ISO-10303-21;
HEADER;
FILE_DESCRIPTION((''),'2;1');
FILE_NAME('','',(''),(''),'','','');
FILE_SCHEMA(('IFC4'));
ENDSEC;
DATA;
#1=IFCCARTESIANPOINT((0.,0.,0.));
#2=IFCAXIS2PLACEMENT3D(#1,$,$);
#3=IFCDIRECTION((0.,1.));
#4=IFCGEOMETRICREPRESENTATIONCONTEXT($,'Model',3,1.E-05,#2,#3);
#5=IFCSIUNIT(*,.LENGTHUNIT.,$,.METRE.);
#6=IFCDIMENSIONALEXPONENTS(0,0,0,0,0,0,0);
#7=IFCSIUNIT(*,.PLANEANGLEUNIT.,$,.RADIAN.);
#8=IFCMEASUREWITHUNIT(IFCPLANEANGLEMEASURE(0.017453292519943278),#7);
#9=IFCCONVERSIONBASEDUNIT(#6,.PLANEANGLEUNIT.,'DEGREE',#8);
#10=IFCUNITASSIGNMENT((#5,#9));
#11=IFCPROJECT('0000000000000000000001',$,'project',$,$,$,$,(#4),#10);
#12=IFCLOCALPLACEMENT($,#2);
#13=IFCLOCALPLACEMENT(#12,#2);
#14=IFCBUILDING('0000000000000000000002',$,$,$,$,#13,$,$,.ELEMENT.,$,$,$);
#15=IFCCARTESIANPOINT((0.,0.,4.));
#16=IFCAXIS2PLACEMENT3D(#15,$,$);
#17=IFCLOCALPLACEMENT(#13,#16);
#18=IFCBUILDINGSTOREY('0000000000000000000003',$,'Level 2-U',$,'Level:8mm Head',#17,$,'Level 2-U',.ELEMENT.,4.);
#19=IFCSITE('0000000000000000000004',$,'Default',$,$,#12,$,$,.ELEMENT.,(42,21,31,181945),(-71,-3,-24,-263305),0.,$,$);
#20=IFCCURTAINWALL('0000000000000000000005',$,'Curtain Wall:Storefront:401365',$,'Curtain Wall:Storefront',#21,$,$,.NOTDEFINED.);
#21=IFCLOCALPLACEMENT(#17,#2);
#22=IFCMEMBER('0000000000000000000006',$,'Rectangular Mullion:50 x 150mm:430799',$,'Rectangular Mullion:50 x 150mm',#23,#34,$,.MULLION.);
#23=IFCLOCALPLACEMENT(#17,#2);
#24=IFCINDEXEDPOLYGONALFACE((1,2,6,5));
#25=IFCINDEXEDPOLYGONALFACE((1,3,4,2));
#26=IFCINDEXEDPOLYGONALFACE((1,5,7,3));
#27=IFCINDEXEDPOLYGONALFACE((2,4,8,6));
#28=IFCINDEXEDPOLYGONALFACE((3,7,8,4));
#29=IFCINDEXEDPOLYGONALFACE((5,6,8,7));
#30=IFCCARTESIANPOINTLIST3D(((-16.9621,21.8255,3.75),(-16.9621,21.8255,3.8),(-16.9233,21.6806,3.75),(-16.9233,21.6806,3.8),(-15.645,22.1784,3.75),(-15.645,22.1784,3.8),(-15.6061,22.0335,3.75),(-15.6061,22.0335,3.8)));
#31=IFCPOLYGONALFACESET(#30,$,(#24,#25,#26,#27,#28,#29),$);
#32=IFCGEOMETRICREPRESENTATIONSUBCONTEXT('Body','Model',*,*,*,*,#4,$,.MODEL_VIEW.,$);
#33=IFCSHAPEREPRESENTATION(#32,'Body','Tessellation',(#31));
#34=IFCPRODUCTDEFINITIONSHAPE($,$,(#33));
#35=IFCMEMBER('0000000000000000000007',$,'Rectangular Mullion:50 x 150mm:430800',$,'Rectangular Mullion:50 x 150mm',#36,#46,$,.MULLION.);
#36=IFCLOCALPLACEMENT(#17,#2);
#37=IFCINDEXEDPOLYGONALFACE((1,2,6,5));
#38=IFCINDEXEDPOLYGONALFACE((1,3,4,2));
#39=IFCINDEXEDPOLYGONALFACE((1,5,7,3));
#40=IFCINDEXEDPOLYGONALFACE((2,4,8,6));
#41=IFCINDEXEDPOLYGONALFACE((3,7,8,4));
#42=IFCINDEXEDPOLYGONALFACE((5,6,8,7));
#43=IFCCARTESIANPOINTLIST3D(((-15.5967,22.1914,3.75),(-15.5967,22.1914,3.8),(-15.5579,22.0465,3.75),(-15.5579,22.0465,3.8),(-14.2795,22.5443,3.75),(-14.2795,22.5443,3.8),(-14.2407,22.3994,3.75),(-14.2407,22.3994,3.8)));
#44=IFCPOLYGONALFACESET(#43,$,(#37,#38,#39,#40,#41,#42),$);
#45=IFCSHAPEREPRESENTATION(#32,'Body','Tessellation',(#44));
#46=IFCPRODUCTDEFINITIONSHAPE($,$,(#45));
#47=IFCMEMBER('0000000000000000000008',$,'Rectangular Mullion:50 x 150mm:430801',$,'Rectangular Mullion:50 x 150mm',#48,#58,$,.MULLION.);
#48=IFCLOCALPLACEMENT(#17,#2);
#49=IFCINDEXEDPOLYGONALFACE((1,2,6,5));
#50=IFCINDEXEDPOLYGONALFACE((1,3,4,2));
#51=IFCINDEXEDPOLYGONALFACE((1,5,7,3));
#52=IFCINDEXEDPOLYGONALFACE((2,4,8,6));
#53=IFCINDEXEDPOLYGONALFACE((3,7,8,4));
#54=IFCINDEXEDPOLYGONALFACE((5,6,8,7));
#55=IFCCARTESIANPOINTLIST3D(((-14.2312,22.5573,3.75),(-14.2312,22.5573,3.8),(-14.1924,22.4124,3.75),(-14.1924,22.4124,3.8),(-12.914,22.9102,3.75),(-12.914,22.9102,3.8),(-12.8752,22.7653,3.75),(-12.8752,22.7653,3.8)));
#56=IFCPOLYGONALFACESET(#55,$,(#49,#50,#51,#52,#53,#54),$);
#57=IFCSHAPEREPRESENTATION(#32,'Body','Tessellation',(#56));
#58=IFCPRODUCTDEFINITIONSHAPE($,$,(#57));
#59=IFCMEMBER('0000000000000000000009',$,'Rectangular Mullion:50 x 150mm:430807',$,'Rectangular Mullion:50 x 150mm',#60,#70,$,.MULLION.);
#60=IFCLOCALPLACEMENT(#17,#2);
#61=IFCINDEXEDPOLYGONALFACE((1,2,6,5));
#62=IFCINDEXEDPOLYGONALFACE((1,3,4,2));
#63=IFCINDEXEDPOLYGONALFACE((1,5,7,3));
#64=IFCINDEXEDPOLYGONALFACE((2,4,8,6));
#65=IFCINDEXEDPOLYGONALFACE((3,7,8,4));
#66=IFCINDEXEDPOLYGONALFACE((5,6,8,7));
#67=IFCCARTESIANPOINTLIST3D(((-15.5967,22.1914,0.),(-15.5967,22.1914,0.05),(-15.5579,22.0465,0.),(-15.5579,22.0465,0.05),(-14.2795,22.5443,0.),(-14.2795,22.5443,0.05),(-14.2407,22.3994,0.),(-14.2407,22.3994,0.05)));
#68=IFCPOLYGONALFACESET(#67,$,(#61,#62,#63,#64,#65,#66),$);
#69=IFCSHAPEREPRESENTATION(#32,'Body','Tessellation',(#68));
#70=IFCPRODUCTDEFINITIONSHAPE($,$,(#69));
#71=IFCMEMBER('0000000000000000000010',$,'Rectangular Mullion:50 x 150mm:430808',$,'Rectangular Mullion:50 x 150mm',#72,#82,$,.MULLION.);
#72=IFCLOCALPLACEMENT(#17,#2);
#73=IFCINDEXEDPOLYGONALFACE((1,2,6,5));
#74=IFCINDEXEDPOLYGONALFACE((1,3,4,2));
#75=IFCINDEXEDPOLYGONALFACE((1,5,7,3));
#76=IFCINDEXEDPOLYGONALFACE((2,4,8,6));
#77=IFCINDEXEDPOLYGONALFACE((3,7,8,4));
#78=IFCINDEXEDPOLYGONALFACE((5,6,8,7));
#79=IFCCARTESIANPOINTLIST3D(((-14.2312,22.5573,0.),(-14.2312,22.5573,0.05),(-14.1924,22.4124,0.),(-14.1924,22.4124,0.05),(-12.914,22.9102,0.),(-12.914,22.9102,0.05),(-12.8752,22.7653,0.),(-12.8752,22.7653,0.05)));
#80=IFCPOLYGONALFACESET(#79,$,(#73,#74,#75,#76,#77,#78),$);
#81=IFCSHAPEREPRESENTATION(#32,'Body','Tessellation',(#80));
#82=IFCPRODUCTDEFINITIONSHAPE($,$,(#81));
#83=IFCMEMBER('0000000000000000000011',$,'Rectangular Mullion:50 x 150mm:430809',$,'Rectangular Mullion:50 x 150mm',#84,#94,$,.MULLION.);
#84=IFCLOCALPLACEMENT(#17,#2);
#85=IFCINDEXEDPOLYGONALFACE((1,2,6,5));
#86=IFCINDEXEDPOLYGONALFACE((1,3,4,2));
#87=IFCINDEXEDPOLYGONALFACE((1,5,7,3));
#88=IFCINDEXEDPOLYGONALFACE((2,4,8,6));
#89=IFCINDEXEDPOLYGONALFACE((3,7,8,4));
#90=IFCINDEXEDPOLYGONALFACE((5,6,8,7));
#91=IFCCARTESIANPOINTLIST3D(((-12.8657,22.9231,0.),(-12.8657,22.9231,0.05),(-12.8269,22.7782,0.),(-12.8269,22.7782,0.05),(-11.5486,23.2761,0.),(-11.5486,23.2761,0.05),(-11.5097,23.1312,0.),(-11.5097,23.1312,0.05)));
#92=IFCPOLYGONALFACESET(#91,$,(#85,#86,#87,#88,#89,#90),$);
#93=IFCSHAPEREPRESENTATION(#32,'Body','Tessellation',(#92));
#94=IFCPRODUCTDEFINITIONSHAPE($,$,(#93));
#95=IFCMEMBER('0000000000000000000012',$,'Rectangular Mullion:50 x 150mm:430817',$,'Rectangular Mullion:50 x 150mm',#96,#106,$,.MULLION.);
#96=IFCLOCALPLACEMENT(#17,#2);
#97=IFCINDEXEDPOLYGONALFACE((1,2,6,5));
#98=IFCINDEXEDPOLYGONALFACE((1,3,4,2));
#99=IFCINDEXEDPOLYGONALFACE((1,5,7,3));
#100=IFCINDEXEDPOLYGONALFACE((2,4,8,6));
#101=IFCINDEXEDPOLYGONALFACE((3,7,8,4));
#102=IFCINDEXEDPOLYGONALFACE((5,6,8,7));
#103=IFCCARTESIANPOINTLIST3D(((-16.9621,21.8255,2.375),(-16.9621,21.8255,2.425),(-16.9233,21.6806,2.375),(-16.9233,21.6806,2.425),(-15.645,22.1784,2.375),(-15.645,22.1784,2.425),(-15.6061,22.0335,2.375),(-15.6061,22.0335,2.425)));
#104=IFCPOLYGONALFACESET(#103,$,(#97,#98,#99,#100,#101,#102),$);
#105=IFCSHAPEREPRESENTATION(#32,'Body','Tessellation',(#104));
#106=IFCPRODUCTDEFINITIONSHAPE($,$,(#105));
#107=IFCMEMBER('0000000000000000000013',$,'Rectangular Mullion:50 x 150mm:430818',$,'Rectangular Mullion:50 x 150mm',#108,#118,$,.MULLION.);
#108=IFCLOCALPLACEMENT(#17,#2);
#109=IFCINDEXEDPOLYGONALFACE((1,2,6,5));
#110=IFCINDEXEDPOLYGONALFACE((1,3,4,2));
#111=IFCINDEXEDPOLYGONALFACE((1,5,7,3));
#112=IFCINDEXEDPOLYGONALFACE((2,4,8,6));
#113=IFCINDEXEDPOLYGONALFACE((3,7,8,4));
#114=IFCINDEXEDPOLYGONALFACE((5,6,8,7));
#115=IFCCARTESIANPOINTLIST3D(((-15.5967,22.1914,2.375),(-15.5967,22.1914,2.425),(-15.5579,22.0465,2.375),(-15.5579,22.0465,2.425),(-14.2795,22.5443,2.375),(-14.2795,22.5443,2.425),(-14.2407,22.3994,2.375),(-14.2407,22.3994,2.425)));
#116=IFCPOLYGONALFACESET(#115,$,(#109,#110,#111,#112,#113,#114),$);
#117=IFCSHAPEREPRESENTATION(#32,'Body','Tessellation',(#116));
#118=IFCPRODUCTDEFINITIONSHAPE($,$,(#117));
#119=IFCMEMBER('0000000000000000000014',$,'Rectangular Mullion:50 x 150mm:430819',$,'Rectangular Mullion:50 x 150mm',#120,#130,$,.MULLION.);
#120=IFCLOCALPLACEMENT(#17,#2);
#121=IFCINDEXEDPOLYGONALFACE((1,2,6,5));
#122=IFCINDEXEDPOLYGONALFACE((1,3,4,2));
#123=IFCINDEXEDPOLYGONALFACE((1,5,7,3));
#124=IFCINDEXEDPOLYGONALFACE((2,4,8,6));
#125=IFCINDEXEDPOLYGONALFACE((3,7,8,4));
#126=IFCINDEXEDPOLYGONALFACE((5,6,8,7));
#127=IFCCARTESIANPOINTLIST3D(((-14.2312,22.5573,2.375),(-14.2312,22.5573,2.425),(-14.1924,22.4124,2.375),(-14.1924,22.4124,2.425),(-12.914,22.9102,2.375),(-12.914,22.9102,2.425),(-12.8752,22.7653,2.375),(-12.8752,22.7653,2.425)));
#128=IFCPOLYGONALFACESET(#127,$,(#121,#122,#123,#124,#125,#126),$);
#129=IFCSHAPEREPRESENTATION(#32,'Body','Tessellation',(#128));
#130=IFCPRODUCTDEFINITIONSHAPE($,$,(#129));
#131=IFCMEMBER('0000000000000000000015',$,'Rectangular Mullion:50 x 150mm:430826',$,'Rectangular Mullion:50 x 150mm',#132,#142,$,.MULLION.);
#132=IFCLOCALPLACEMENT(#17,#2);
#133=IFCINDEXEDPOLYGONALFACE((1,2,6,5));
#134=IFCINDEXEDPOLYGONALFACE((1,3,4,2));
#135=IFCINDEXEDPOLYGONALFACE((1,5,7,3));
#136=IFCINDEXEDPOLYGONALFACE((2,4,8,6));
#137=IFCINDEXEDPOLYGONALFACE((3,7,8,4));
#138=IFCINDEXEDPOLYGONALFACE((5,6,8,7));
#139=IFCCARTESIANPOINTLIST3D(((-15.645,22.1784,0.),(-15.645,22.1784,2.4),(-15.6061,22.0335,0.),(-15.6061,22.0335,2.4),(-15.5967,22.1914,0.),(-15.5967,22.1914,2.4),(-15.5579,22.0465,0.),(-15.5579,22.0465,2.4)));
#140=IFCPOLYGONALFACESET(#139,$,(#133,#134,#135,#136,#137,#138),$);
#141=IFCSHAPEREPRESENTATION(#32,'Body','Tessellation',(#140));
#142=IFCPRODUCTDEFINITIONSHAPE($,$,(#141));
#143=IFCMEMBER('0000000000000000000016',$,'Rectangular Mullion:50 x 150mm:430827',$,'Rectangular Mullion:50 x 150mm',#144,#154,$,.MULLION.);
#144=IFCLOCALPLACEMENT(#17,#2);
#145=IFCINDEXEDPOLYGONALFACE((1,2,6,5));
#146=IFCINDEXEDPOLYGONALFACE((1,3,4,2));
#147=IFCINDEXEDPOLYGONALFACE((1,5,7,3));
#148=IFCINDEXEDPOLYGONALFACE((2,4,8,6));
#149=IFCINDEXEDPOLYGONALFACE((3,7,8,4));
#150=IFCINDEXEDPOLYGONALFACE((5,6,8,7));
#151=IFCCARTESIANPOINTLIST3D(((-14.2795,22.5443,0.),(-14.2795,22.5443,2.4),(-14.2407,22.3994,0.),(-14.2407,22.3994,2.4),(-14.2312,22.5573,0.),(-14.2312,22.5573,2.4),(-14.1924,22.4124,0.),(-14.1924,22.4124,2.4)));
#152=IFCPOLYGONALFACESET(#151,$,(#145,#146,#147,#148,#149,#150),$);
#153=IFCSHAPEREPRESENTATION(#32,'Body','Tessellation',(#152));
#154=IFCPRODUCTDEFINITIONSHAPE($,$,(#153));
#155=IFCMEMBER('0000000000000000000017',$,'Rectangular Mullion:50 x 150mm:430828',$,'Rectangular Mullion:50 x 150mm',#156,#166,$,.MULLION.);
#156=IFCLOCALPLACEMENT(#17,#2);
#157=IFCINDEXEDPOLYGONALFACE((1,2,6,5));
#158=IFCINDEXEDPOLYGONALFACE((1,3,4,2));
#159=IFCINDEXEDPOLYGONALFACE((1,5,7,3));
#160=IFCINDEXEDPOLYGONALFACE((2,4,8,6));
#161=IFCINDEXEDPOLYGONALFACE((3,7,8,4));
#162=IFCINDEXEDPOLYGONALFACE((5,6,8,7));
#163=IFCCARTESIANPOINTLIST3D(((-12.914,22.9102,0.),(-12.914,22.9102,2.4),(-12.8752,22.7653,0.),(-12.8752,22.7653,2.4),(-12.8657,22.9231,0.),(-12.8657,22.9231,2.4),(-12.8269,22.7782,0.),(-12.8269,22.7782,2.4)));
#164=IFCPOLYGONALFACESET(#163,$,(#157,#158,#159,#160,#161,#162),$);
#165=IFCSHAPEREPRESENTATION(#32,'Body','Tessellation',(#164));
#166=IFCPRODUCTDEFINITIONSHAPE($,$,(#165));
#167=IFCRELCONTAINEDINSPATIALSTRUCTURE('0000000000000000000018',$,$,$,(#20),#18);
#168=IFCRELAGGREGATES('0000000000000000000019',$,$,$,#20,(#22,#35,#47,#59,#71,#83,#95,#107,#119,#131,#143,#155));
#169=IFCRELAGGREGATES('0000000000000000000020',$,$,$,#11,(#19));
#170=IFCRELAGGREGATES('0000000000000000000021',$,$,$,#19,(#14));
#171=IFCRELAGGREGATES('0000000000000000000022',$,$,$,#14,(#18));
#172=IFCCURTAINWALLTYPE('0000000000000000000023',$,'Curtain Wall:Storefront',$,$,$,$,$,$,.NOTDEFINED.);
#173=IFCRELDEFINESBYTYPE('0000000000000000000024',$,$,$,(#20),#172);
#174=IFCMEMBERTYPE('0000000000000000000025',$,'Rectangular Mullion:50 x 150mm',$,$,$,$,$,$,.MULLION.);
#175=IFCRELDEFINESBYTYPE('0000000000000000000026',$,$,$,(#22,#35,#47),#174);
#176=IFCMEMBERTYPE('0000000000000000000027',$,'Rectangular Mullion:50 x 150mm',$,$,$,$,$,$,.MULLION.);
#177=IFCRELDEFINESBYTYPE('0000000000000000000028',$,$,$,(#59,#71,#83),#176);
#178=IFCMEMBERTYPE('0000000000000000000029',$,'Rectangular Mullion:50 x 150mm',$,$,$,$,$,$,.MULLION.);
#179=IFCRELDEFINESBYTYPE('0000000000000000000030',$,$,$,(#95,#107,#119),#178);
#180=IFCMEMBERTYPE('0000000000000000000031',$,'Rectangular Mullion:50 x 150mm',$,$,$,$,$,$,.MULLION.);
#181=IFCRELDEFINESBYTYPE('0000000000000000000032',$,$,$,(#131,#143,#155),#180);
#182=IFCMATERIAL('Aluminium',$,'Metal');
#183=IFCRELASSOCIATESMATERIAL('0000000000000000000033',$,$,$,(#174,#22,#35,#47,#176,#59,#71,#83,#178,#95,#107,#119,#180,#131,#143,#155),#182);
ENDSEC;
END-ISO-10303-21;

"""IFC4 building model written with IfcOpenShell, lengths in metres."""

from ifc_helpers import new_model, entity, si_unit, converted_unit, direction, frame, origin, place, context, subcontext, project, spatial, indexed_curve, outline, extrude, source, transform, mapped, material, type_object, type_shapes, element, aggregate, save


model = new_model("IFC4")

# Units and contexts
model_context = context("Model", 3, precision=1e-05, world=origin(), true_north=direction((0.0, 1.0)))
body_context = subcontext(model_context, "Body", "Model", "MODEL_VIEW")
ifc_project = project(units=[si_unit("LENGTHUNIT", "METRE"), converted_unit("PLANEANGLEUNIT", "DEGREE", entity("IfcPlaneAngleMeasure", 0.017453292519943278), si_unit("PLANEANGLEUNIT", "RADIAN"), dimensions=[0, 0, 0, 0, 0, 0, 0])], contexts=[model_context])

# Site, building, storey
site_placement = place(None, origin())
site = spatial("IfcSite", under=ifc_project, at=site_placement, Name="Default", CompositionType="ELEMENT", RefLatitude=(42, 21, 31, 181945), RefLongitude=(-71, -3, -24, -263305), RefElevation=0.0)
building_placement = place(site_placement, origin())
building = spatial("IfcBuilding", under=site, at=building_placement, CompositionType="ELEMENT")
storey_placement = place(building_placement, frame((0.0, 0.0, 4.0)))
storey = spatial("IfcBuildingStorey", under=building, at=storey_placement, Name="Level 2-U", ObjectType="Level:8mm Head", LongName="Level 2-U", CompositionType="ELEMENT", Elevation=4.0)

# Curtain wall, members
curtain_wall_type = type_object("IfcCurtainWallType", Name="Curtain Wall:Storefront", PredefinedType="NOTDEFINED")
curtain_wall_placement = place(storey_placement, frame((0.0, 0.0, -4.0)))
curtain_wall = element("IfcCurtainWall", 1, at=curtain_wall_placement, inside=storey, type_object=curtain_wall_type, Name="Curtain Wall:Storefront:401365", ObjectType="Curtain Wall:Storefront", PredefinedType="NOTDEFINED")
ifc_material_1 = material(Name="Aluminium", Category="Metal")
member_type_1 = type_object("IfcMemberType", Name="Rectangular Mullion:50 x 150mm", PredefinedType="MULLION", material=ifc_material_1)
shared_shape_1 = source(origin(), body_context, "Body", "SweptSolid", [
    extrude(outline(indexed_curve([(-0.025, -0.075), (0.025, -0.075), (0.025, 0.075), (-0.025, 0.075), (-0.025, -0.075)], self_intersect=False)), frame((-0.025, 0.0, -1.3636), z_axis=(0.0, 0.0, 1.0), x_axis=(-1.0, 0.0, 0.0)), (0.0, 0.0, 1.0), 1.3636),
])
type_shapes(member_type_1, [shared_shape_1])
member_1_placement = place(curtain_wall_placement, frame((-15.6256, 22.106, 7.8), z_axis=(0.965926, 0.258819, 0.0), x_axis=(0.0, 0.0, 1.0)))
member_1 = element("IfcMember", 2, at=member_1_placement, type_object=member_type_1, material=ifc_material_1, Name="Rectangular Mullion:50 x 150mm:430799", ObjectType="Rectangular Mullion:50 x 150mm", PredefinedType="MULLION", context=body_context, shape_type="MappedRepresentation", body=[
    mapped(shared_shape_1, transform((0.0, 0.0, 0.0), scale=1.0)),
])
member_2_placement = place(curtain_wall_placement, frame((-14.2601, 22.4719, 7.8), z_axis=(0.965926, 0.258819, 0.0), x_axis=(0.0, 0.0, 1.0)))
member_2 = element("IfcMember", 3, at=member_2_placement, type_object=member_type_1, material=ifc_material_1, Name="Rectangular Mullion:50 x 150mm:430800", ObjectType="Rectangular Mullion:50 x 150mm", PredefinedType="MULLION", context=body_context, shape_type="MappedRepresentation", body=[
    mapped(shared_shape_1, transform((0.0, 0.0, 0.0), scale=1.0)),
])
member_3_placement = place(curtain_wall_placement, frame((-12.8946, 22.8377, 7.8), z_axis=(0.965926, 0.258819, 0.0), x_axis=(0.0, 0.0, 1.0)))
member_3 = element("IfcMember", 4, at=member_3_placement, type_object=member_type_1, material=ifc_material_1, Name="Rectangular Mullion:50 x 150mm:430801", ObjectType="Rectangular Mullion:50 x 150mm", PredefinedType="MULLION", context=body_context, shape_type="MappedRepresentation", body=[
    mapped(shared_shape_1, transform((0.0, 0.0, 0.0), scale=1.0)),
])
member_type_2 = type_object("IfcMemberType", Name="Rectangular Mullion:50 x 150mm", PredefinedType="MULLION", material=ifc_material_1)
shared_shape_2 = source(origin(), body_context, "Body", "SweptSolid", [
    extrude(outline(indexed_curve([(-0.025, -0.075), (0.025, -0.075), (0.025, 0.075), (-0.025, 0.075), (-0.025, -0.075)], self_intersect=False)), frame((-0.025, 0.0, -1.3636), z_axis=(0.0, 0.0, 1.0), x_axis=(-1.0, 0.0, 0.0)), (0.0, 0.0, 1.0), 1.3636),
])
type_shapes(member_type_2, [shared_shape_2])
member_4_placement = place(curtain_wall_placement, frame((-15.5773, 22.1189, 4.0), z_axis=(-0.965926, -0.258819, 0.0), x_axis=(0.0, 0.0, -1.0)))
member_4 = element("IfcMember", 5, at=member_4_placement, type_object=member_type_2, material=ifc_material_1, Name="Rectangular Mullion:50 x 150mm:430807", ObjectType="Rectangular Mullion:50 x 150mm", PredefinedType="MULLION", context=body_context, shape_type="MappedRepresentation", body=[
    mapped(shared_shape_2, transform((0.0, 0.0, 0.0), scale=1.0)),
])
member_5_placement = place(curtain_wall_placement, frame((-14.2118, 22.4848, 4.0), z_axis=(-0.965926, -0.258819, 0.0), x_axis=(0.0, 0.0, -1.0)))
member_5 = element("IfcMember", 6, at=member_5_placement, type_object=member_type_2, material=ifc_material_1, Name="Rectangular Mullion:50 x 150mm:430808", ObjectType="Rectangular Mullion:50 x 150mm", PredefinedType="MULLION", context=body_context, shape_type="MappedRepresentation", body=[
    mapped(shared_shape_2, transform((0.0, 0.0, 0.0), scale=1.0)),
])
member_6_placement = place(curtain_wall_placement, frame((-12.8463, 22.8507, 4.0), z_axis=(-0.965926, -0.258819, 0.0), x_axis=(0.0, 0.0, -1.0)))
member_6 = element("IfcMember", 7, at=member_6_placement, type_object=member_type_2, material=ifc_material_1, Name="Rectangular Mullion:50 x 150mm:430809", ObjectType="Rectangular Mullion:50 x 150mm", PredefinedType="MULLION", context=body_context, shape_type="MappedRepresentation", body=[
    mapped(shared_shape_2, transform((0.0, 0.0, 0.0), scale=1.0)),
])
member_type_3 = type_object("IfcMemberType", Name="Rectangular Mullion:50 x 150mm", PredefinedType="MULLION", material=ifc_material_1)
shared_shape_3 = source(origin(), body_context, "Body", "SweptSolid", [
    extrude(outline(indexed_curve([(-0.025, -0.075), (0.025, -0.075), (0.025, 0.075), (-0.025, 0.075), (-0.025, -0.075)], self_intersect=False)), frame((0.0, 0.0, -1.3636), z_axis=(0.0, 0.0, 1.0), x_axis=(-1.0, 0.0, 0.0)), (0.0, 0.0, 1.0), 1.3636),
])
type_shapes(member_type_3, [shared_shape_3])
member_7_placement = place(curtain_wall_placement, frame((-15.6256, 22.106, 6.4), z_axis=(0.965926, 0.258819, 0.0), x_axis=(0.0, 0.0, 1.0)))
member_7 = element("IfcMember", 8, at=member_7_placement, type_object=member_type_3, material=ifc_material_1, Name="Rectangular Mullion:50 x 150mm:430817", ObjectType="Rectangular Mullion:50 x 150mm", PredefinedType="MULLION", context=body_context, shape_type="MappedRepresentation", body=[
    mapped(shared_shape_3, transform((0.0, 0.0, 0.0), scale=1.0)),
])
member_8_placement = place(curtain_wall_placement, frame((-14.2601, 22.4719, 6.4), z_axis=(0.965926, 0.258819, 0.0), x_axis=(0.0, 0.0, 1.0)))
member_8 = element("IfcMember", 9, at=member_8_placement, type_object=member_type_3, material=ifc_material_1, Name="Rectangular Mullion:50 x 150mm:430818", ObjectType="Rectangular Mullion:50 x 150mm", PredefinedType="MULLION", context=body_context, shape_type="MappedRepresentation", body=[
    mapped(shared_shape_3, transform((0.0, 0.0, 0.0), scale=1.0)),
])
member_9_placement = place(curtain_wall_placement, frame((-12.8946, 22.8377, 6.4), z_axis=(0.965926, 0.258819, 0.0), x_axis=(0.0, 0.0, 1.0)))
member_9 = element("IfcMember", 10, at=member_9_placement, type_object=member_type_3, material=ifc_material_1, Name="Rectangular Mullion:50 x 150mm:430819", ObjectType="Rectangular Mullion:50 x 150mm", PredefinedType="MULLION", context=body_context, shape_type="MappedRepresentation", body=[
    mapped(shared_shape_3, transform((0.0, 0.0, 0.0), scale=1.0)),
])
member_type_4 = type_object("IfcMemberType", Name="Rectangular Mullion:50 x 150mm", PredefinedType="MULLION", material=ifc_material_1)
shared_shape_4 = source(origin(), body_context, "Body", "SweptSolid", [
    extrude(outline(indexed_curve([(-0.025, -0.075), (0.025, -0.075), (0.025, 0.075), (-0.025, 0.075), (-0.025, -0.075)], self_intersect=False)), frame((0.0, 0.0, -2.4), z_axis=(0.0, 0.0, 1.0), x_axis=(-1.0, 0.0, 0.0)), (0.0, 0.0, 1.0), 2.4),
])
type_shapes(member_type_4, [shared_shape_4])
member_10_placement = place(curtain_wall_placement, frame((-15.6014, 22.1125, 4.0), z_axis=(0.0, 0.0, -1.0), x_axis=(0.965926, 0.258819, 0.0)))
member_10 = element("IfcMember", 11, at=member_10_placement, type_object=member_type_4, material=ifc_material_1, Name="Rectangular Mullion:50 x 150mm:430826", ObjectType="Rectangular Mullion:50 x 150mm", PredefinedType="MULLION", context=body_context, shape_type="MappedRepresentation", body=[
    mapped(shared_shape_4, transform((0.0, 0.0, 0.0), scale=1.0)),
])
member_11_placement = place(curtain_wall_placement, frame((-14.2359, 22.4783, 4.0), z_axis=(0.0, 0.0, -1.0), x_axis=(0.965926, 0.258819, 0.0)))
member_11 = element("IfcMember", 12, at=member_11_placement, type_object=member_type_4, material=ifc_material_1, Name="Rectangular Mullion:50 x 150mm:430827", ObjectType="Rectangular Mullion:50 x 150mm", PredefinedType="MULLION", context=body_context, shape_type="MappedRepresentation", body=[
    mapped(shared_shape_4, transform((0.0, 0.0, 0.0), scale=1.0)),
])
member_12_placement = place(curtain_wall_placement, frame((-12.8705, 22.8442, 4.0), z_axis=(0.0, 0.0, -1.0), x_axis=(0.965926, 0.258819, 0.0)))
member_12 = element("IfcMember", 13, at=member_12_placement, type_object=member_type_4, material=ifc_material_1, Name="Rectangular Mullion:50 x 150mm:430828", ObjectType="Rectangular Mullion:50 x 150mm", PredefinedType="MULLION", context=body_context, shape_type="MappedRepresentation", body=[
    mapped(shared_shape_4, transform((0.0, 0.0, 0.0), scale=1.0)),
])
aggregate(curtain_wall, [member_1, member_2, member_3, member_4, member_5, member_6, member_7, member_8, member_9, member_10, member_11, member_12])

save(model, "model.ifc")
